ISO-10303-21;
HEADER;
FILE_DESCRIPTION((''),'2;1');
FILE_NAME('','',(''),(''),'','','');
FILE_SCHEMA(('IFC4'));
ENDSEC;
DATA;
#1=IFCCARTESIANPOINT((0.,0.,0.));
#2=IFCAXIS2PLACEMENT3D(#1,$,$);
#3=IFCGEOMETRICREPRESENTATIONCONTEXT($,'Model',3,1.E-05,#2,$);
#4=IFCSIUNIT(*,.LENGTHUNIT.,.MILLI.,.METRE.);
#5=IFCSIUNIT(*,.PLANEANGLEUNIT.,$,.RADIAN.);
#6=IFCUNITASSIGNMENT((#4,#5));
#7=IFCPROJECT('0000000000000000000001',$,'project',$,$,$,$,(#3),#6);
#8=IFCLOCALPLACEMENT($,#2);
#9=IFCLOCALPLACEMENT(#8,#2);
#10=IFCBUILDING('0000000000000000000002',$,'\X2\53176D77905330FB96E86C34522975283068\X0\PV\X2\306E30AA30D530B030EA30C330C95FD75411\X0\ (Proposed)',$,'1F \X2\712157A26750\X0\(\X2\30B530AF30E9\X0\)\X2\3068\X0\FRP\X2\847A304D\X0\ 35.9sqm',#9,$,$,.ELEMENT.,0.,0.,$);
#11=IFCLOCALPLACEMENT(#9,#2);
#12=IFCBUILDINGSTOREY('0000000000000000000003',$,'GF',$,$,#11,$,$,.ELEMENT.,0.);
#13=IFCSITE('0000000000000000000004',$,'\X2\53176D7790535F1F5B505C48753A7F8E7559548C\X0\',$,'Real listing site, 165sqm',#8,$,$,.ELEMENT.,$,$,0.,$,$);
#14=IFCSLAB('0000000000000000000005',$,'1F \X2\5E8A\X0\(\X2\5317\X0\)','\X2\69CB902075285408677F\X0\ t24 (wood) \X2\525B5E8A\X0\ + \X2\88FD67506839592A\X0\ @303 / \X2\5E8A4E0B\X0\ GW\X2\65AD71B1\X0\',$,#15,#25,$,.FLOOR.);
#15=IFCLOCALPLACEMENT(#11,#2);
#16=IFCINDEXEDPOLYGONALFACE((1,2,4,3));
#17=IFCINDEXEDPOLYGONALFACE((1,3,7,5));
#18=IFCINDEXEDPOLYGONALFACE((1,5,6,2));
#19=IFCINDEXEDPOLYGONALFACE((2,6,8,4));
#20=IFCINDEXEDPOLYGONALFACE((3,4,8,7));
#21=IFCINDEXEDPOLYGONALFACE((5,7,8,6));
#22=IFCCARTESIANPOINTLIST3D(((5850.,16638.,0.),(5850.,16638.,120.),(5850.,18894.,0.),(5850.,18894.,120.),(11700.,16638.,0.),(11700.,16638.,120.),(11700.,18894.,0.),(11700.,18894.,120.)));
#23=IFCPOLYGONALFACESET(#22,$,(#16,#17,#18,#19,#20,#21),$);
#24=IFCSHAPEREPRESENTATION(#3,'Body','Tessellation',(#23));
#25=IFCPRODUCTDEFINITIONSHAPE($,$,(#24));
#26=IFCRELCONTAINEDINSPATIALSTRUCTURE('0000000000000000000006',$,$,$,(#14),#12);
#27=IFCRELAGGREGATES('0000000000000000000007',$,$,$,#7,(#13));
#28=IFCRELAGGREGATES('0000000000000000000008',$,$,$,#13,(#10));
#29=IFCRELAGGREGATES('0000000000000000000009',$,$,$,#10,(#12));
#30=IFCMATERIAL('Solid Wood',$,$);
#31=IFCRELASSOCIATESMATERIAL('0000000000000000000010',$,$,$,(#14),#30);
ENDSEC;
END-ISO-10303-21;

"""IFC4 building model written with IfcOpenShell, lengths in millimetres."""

from ifc_helpers import new_model, si_unit, frame, frame_2d, origin, place, context, project, spatial, rectangle, extrude, material, element, save


model = new_model("IFC4")

# Units and contexts
model_context = context("Model", 3, precision=1e-05, world=origin())
ifc_project = project(units=[si_unit("LENGTHUNIT", "METRE", prefix="MILLI"), si_unit("PLANEANGLEUNIT", "RADIAN")], contexts=[model_context])

# Site, building, storey
site_placement = place(None, origin())
site = spatial("IfcSite", under=ifc_project, at=site_placement, Name="北海道弟子屈町美留和", ObjectType="Real listing site, 165sqm", CompositionType="ELEMENT", RefElevation=0.0)
building_placement = place(site_placement, origin())
building = spatial("IfcBuilding", under=site, at=building_placement, Name="北海道・雨水利用とPVのオフグリッド志向 (Proposed)", ObjectType="1F 無垢材(サクラ)とFRP葺き 35.9sqm", CompositionType="ELEMENT", ElevationOfRefHeight=0.0, ElevationOfTerrain=0.0)
storey_placement = place(building_placement, origin())
storey = spatial("IfcBuildingStorey", under=building, at=storey_placement, Name="GF", CompositionType="ELEMENT", Elevation=0.0)

# Shared definitions
ifc_material_1 = material(Name="Solid Wood")

# Slab
slab_1_placement = place(storey_placement, frame((2925.0, 8319.0, 0.0)))
element("IfcSlab", 1, at=slab_1_placement, inside=storey, material=ifc_material_1, Name="1F 床(北)", Description="構造用合板 t24 (wood) 剛床 + 製材根太 @303 / 床下 GW断熱", PredefinedType="FLOOR", context=model_context, shape_type="SweptSolid", body=[
    extrude(rectangle(XDim=5850.0, YDim=2256.0, at=frame_2d((2925.0, 1128.0))), frame((2925.0, 8319.0, 0.0)), (0.0, 0.0, 1.0), 120.0),
])

save(model, "model.ifc")
